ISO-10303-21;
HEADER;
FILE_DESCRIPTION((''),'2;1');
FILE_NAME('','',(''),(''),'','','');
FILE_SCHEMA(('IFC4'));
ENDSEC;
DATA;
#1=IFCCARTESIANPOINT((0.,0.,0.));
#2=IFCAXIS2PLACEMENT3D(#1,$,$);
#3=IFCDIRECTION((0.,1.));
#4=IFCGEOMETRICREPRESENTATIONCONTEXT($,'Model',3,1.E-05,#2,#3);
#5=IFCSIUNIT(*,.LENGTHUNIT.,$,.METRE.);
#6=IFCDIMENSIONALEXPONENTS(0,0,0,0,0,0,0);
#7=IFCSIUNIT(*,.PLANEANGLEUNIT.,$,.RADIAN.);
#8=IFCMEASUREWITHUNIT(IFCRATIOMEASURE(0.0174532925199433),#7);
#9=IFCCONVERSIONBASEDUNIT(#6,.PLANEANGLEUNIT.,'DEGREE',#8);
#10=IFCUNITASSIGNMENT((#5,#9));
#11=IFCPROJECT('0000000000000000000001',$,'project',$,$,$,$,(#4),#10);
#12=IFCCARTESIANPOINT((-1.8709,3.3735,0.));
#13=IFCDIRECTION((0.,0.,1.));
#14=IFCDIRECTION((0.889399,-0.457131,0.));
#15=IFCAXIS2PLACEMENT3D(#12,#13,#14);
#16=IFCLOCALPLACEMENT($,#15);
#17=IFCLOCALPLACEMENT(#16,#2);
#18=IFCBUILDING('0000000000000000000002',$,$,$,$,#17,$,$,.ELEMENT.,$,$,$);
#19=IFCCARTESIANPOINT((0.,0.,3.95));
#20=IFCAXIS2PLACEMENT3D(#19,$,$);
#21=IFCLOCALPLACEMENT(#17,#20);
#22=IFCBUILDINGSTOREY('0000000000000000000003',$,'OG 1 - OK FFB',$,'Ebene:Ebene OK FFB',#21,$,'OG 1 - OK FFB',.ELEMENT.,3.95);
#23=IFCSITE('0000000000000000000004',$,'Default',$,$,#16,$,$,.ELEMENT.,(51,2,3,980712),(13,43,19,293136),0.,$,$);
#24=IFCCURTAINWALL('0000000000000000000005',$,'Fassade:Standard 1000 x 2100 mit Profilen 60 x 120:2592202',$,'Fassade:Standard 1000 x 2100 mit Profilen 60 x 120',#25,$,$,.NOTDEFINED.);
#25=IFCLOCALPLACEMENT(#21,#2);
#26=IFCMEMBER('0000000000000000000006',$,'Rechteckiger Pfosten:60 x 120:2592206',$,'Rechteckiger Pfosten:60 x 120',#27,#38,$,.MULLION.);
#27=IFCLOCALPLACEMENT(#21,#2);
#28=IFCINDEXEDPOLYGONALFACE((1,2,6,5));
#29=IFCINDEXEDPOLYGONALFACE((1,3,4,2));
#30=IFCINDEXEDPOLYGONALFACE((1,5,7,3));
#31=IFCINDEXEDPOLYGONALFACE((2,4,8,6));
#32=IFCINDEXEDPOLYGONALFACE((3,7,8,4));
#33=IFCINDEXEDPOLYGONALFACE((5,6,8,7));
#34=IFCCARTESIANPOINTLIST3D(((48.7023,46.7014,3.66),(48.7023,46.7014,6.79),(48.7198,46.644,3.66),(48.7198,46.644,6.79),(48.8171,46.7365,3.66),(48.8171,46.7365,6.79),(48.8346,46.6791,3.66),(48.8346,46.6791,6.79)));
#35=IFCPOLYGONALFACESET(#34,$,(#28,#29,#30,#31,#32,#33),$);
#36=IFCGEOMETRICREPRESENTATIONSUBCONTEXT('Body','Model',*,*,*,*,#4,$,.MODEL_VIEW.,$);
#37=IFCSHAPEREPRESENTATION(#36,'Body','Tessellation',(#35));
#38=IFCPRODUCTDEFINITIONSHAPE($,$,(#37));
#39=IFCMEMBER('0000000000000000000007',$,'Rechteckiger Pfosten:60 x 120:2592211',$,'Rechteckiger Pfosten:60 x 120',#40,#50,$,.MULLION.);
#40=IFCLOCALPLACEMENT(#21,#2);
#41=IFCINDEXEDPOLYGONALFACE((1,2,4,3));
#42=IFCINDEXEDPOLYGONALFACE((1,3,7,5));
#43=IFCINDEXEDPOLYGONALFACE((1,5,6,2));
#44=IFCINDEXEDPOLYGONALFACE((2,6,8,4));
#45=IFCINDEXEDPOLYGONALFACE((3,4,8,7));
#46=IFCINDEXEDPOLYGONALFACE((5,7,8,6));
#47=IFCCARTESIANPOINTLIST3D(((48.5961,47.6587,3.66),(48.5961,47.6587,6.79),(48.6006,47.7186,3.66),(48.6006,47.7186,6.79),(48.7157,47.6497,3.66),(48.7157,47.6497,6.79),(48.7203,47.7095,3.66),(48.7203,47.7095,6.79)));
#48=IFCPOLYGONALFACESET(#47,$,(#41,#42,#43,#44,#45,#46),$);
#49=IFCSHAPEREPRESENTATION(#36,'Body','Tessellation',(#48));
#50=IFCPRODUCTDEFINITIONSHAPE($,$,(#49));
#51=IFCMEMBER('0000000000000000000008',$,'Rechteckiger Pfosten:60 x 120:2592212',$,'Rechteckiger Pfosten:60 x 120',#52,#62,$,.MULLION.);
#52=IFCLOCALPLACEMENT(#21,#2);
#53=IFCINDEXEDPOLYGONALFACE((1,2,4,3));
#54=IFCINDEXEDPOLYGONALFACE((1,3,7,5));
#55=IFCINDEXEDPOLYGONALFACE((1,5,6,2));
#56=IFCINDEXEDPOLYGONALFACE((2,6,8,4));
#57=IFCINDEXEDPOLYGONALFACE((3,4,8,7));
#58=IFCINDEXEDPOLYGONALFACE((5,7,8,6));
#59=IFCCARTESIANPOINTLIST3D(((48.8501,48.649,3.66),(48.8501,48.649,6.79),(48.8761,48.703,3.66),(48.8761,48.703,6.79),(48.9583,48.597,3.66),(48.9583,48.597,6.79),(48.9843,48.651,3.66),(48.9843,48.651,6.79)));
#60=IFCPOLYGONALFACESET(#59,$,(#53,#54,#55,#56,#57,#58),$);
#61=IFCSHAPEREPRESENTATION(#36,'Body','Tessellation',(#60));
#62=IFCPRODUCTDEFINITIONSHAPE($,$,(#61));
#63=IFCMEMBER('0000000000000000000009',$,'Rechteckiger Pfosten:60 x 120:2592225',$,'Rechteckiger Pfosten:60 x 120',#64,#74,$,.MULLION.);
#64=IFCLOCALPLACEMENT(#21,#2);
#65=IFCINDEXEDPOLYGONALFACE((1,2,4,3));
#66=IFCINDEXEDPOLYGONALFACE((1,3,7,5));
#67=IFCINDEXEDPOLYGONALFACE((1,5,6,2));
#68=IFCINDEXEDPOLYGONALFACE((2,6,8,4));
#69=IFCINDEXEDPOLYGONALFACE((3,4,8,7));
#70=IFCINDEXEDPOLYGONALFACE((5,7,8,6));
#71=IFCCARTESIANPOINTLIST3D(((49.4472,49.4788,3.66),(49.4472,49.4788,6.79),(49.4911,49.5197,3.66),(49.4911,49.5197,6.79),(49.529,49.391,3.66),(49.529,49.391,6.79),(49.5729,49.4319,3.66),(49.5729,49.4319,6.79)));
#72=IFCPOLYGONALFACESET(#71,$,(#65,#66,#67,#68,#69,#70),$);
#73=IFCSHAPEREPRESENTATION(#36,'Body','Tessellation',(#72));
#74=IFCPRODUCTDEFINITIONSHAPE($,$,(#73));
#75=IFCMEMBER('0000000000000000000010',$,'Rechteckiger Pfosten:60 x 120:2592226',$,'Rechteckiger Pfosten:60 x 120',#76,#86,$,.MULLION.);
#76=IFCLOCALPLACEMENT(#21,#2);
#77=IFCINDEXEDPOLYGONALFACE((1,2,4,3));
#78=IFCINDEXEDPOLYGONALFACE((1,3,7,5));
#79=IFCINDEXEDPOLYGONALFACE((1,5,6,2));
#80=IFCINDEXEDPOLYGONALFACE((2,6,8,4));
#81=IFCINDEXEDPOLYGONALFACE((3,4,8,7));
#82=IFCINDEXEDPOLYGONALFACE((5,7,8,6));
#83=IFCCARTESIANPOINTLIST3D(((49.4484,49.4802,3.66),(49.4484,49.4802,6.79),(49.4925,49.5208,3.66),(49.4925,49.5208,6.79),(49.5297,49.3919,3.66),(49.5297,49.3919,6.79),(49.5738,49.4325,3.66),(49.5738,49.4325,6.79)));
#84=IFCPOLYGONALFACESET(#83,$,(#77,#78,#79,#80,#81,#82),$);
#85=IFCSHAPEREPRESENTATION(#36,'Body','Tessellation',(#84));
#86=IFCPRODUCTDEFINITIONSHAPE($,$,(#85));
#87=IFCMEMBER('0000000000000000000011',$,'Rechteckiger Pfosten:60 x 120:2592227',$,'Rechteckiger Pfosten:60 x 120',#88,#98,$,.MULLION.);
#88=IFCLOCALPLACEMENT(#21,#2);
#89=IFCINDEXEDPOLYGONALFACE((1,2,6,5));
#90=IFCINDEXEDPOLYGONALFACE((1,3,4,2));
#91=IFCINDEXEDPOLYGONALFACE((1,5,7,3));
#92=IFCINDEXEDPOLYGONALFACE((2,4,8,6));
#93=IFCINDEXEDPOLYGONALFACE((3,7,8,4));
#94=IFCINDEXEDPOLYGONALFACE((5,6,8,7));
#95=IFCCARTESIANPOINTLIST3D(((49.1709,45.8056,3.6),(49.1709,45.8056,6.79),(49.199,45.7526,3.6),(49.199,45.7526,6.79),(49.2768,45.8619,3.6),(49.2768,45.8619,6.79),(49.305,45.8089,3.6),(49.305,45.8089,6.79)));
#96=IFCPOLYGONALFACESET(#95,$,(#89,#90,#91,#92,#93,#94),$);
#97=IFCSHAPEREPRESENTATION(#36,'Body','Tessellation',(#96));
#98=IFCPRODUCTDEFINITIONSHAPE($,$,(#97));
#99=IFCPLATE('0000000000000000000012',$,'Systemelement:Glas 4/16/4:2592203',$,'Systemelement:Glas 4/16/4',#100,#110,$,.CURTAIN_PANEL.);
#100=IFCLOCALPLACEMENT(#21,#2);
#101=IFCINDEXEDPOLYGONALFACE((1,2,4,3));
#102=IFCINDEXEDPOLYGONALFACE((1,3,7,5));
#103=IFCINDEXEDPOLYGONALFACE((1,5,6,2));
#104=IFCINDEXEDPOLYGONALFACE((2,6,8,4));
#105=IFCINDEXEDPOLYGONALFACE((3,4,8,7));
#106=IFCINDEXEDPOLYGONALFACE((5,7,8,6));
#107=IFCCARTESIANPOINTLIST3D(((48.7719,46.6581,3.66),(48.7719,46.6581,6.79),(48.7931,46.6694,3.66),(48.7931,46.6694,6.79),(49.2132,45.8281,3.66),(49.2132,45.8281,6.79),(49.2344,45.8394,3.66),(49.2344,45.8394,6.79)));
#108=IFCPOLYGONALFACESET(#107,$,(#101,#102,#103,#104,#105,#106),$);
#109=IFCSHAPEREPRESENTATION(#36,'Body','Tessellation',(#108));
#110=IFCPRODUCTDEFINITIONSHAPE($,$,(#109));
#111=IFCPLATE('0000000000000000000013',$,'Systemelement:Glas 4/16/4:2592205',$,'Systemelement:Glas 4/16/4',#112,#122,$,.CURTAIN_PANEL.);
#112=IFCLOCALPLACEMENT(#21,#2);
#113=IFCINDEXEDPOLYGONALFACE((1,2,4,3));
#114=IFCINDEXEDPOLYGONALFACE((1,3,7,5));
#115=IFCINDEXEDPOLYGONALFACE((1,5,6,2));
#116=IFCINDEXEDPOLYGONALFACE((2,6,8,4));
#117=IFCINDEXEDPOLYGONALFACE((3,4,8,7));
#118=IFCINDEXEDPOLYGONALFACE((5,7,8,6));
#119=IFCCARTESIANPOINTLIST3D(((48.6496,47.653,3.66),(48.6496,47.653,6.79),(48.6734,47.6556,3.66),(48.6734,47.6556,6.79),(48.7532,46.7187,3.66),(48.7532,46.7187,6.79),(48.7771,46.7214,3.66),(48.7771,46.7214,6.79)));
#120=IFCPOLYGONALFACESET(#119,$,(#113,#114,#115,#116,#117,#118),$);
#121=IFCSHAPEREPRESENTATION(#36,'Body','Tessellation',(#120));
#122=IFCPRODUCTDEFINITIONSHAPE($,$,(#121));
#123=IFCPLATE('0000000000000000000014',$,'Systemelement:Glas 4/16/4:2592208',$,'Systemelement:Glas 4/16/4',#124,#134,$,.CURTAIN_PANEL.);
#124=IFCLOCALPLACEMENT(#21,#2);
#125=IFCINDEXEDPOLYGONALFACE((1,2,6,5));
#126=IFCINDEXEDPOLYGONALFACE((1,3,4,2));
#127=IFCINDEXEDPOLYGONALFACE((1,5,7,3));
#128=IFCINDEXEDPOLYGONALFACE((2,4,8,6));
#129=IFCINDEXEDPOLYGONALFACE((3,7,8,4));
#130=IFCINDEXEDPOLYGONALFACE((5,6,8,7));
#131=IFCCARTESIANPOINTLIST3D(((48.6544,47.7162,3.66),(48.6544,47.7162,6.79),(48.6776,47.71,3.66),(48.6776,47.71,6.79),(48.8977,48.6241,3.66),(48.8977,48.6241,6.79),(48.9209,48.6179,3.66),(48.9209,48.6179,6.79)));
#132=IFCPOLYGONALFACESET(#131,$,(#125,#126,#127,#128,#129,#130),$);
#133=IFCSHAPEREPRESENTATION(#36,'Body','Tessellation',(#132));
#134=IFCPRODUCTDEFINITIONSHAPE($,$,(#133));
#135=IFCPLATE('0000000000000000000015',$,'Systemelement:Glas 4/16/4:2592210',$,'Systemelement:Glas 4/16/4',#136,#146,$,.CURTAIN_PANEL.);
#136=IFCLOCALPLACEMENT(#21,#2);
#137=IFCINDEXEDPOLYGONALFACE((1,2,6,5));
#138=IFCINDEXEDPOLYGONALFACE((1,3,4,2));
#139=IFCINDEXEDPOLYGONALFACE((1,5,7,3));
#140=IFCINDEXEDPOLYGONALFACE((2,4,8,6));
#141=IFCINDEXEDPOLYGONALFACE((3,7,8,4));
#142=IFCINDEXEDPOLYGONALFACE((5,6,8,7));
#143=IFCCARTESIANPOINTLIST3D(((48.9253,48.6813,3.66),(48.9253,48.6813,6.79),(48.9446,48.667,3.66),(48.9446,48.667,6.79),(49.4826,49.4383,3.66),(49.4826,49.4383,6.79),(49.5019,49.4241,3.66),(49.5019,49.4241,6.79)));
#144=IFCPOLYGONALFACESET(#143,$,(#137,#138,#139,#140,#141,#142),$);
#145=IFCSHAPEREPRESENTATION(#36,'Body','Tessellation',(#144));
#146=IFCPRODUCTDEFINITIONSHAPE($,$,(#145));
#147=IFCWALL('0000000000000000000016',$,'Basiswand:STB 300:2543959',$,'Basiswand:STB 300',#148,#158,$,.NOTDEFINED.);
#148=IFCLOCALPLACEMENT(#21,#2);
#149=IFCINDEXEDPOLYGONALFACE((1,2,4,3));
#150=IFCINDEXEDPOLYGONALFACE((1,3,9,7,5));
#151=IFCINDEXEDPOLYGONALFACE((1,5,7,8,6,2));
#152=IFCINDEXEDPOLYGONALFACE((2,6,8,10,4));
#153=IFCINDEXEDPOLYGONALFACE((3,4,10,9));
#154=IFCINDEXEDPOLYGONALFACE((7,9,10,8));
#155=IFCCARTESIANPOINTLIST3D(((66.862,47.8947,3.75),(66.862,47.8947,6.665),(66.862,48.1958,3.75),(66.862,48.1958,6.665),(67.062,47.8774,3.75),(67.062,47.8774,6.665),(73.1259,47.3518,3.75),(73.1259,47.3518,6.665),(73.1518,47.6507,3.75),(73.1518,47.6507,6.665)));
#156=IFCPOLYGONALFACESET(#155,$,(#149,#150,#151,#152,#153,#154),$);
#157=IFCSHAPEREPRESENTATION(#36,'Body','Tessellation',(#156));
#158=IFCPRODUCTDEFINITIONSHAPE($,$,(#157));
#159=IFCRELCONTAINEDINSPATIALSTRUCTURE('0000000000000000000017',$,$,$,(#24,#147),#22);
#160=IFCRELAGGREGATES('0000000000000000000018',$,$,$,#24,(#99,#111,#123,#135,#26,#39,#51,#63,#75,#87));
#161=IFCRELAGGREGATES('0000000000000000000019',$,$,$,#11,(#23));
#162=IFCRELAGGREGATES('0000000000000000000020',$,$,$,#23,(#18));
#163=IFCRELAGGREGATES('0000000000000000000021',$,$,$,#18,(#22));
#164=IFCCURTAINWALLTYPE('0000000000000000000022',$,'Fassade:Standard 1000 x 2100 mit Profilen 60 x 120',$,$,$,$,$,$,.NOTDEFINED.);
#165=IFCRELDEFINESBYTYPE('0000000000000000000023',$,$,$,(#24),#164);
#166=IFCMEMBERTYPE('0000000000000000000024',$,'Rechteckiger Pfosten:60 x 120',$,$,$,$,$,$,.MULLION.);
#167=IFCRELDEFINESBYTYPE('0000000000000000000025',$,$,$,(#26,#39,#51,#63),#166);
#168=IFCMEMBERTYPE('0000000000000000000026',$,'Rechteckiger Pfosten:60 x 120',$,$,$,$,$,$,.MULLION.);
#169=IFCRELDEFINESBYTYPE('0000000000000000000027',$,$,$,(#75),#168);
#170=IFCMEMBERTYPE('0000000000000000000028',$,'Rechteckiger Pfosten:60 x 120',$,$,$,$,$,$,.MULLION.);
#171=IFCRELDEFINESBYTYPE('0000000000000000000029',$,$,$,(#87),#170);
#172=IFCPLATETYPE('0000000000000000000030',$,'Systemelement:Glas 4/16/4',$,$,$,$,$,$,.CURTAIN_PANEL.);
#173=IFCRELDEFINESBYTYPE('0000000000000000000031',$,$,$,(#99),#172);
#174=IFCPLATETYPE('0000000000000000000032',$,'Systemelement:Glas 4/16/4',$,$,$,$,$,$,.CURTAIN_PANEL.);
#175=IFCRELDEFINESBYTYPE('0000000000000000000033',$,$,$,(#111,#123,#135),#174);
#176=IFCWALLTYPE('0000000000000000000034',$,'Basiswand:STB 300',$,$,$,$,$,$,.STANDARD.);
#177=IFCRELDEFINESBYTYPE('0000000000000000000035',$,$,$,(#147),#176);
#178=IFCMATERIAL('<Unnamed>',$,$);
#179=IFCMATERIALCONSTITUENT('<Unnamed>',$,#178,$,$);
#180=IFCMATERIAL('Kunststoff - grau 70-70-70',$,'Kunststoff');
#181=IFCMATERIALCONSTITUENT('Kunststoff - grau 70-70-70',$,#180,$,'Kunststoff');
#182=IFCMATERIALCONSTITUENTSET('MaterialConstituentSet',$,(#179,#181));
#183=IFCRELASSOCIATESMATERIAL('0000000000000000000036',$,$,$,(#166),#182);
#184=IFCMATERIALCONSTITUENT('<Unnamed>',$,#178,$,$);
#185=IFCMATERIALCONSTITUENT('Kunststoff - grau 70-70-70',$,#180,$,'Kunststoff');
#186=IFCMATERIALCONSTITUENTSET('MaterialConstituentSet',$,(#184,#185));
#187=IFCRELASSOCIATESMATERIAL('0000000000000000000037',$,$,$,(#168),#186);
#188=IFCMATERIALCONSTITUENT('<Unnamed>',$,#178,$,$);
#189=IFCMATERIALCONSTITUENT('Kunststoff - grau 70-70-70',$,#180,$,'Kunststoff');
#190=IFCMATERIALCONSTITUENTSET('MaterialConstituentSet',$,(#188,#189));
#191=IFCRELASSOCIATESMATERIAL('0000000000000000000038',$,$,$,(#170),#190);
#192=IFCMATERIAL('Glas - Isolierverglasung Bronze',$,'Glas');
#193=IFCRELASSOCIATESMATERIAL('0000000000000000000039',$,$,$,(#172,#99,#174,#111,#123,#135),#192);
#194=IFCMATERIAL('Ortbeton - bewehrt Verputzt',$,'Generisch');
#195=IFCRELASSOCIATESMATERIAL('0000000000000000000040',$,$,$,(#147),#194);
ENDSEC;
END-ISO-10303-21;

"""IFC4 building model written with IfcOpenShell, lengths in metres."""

from ifc_helpers import new_model, entity, si_unit, converted_unit, direction, frame, origin, place, context, subcontext, project, spatial, indexed_curve, outline, extrude, source, transform, mapped, material, constituent, constituent_set, type_object, type_shapes, element, aggregate, save


model = new_model("IFC4")

# Units and contexts
model_context = context("Model", 3, precision=1e-05, world=origin(), true_north=direction((0.0, 1.0)))
body_context = subcontext(model_context, "Body", "Model", "MODEL_VIEW")
ifc_project = project(units=[si_unit("LENGTHUNIT", "METRE"), converted_unit("PLANEANGLEUNIT", "DEGREE", entity("IfcRatioMeasure", 0.0174532925199433), si_unit("PLANEANGLEUNIT", "RADIAN"), dimensions=[0, 0, 0, 0, 0, 0, 0])], contexts=[model_context])

# Site, building, storey
site_placement = place(None, frame((-1.8709, 3.3735, 0.0), z_axis=(0.0, 0.0, 1.0), x_axis=(0.889399, -0.457131, 0.0)))
site = spatial("IfcSite", under=ifc_project, at=site_placement, Name="Default", CompositionType="ELEMENT", RefLatitude=(51, 2, 3, 980712), RefLongitude=(13, 43, 19, 293136), RefElevation=0.0)
building_placement = place(site_placement, origin())
building = spatial("IfcBuilding", under=site, at=building_placement, CompositionType="ELEMENT")
storey_placement = place(building_placement, frame((0.0, 0.0, 3.95)))
storey = spatial("IfcBuildingStorey", under=building, at=storey_placement, Name="OG 1 - OK FFB", ObjectType="Ebene:Ebene OK FFB", LongName="OG 1 - OK FFB", CompositionType="ELEMENT", Elevation=3.95)

# Shared definitions
ifc_material_1 = material(Name="Ortbeton - bewehrt Verputzt", Category="Generisch")

# Curtain wall, members
curtain_wall_type = type_object("IfcCurtainWallType", Name="Fassade:Standard 1000 x 2100 mit Profilen 60 x 120", PredefinedType="NOTDEFINED")
curtain_wall_placement = place(storey_placement, frame((0.0, 0.0, -3.95)))
curtain_wall = element("IfcCurtainWall", 1, at=curtain_wall_placement, inside=storey, type_object=curtain_wall_type, Name="Fassade:Standard 1000 x 2100 mit Profilen 60 x 120:2592202", ObjectType="Fassade:Standard 1000 x 2100 mit Profilen 60 x 120", PredefinedType="NOTDEFINED")
ifc_material_2 = material(Name="<Unnamed>")
ifc_constituent_1 = constituent(ifc_material_2, Name="<Unnamed>")
ifc_material_3 = material(Name="Kunststoff - grau 70-70-70", Category="Kunststoff")
ifc_constituent_2 = constituent(ifc_material_3, Name="Kunststoff - grau 70-70-70", Category="Kunststoff")
ifc_constituent_set_1 = constituent_set(constituents=[ifc_constituent_1, ifc_constituent_2], Name="MaterialConstituentSet")
member_type_1 = type_object("IfcMemberType", Name="Rechteckiger Pfosten:60 x 120", PredefinedType="MULLION", material=ifc_constituent_set_1)
shared_shape_1 = source(origin(), body_context, "Body", "SweptSolid", [
    extrude(outline(indexed_curve([(-0.06, -0.03), (0.06, -0.03), (0.06, 0.03), (-0.06, 0.03), (-0.06, -0.03)], self_intersect=False)), frame((0.0, 0.0, -3.13), z_axis=(0.0, 0.0, 1.0), x_axis=(0.0, -1.0, 0.0)), (0.0, 0.0, 1.0), 3.13),
])
type_shapes(member_type_1, [shared_shape_1])
member_1_placement = place(curtain_wall_placement, frame((48.7685, 46.6902, 7.61), z_axis=(0.0, 0.0, -1.0), x_axis=(-0.292429, 0.956287, 0.0)))
member_1 = element("IfcMember", 2, at=member_1_placement, type_object=member_type_1, Name="Rechteckiger Pfosten:60 x 120:2592206", ObjectType="Rechteckiger Pfosten:60 x 120", PredefinedType="MULLION", context=body_context, shape_type="MappedRepresentation", body=[
    mapped(shared_shape_1, transform((0.0, 0.0, 0.0), scale=1.0)),
])
member_2_placement = place(curtain_wall_placement, frame((48.6582, 47.6841, 7.61), z_axis=(0.0, 0.0, -1.0), x_axis=(0.075683, 0.997132, 0.0)))
member_2 = element("IfcMember", 3, at=member_2_placement, type_object=member_type_1, Name="Rechteckiger Pfosten:60 x 120:2592211", ObjectType="Rechteckiger Pfosten:60 x 120", PredefinedType="MULLION", context=body_context, shape_type="MappedRepresentation", body=[
    mapped(shared_shape_1, transform((0.0, 0.0, 0.0), scale=1.0)),
])
member_3_placement = place(curtain_wall_placement, frame((48.9172, 48.65, 7.61), z_axis=(0.0, 0.0, -1.0), x_axis=(0.433412, 0.901196, 0.0)))
member_3 = element("IfcMember", 4, at=member_3_placement, type_object=member_type_1, Name="Rechteckiger Pfosten:60 x 120:2592212", ObjectType="Rechteckiger Pfosten:60 x 120", PredefinedType="MULLION", context=body_context, shape_type="MappedRepresentation", body=[
    mapped(shared_shape_1, transform((0.0, 0.0, 0.0), scale=1.0)),
])
member_4_placement = place(curtain_wall_placement, frame((49.51, 49.4553, 7.61), z_axis=(0.0, 0.0, -1.0), x_axis=(0.731689, 0.681639, 0.0)))
member_4 = element("IfcMember", 5, at=member_4_placement, type_object=member_type_1, Name="Rechteckiger Pfosten:60 x 120:2592225", ObjectType="Rechteckiger Pfosten:60 x 120", PredefinedType="MULLION", context=body_context, shape_type="MappedRepresentation", body=[
    mapped(shared_shape_1, transform((0.0, 0.0, 0.0), scale=1.0)),
])
ifc_constituent_3 = constituent(ifc_material_2, Name="<Unnamed>")
ifc_constituent_4 = constituent(ifc_material_3, Name="Kunststoff - grau 70-70-70", Category="Kunststoff")
ifc_constituent_set_2 = constituent_set(constituents=[ifc_constituent_3, ifc_constituent_4], Name="MaterialConstituentSet")
member_type_2 = type_object("IfcMemberType", Name="Rechteckiger Pfosten:60 x 120", PredefinedType="MULLION", material=ifc_constituent_set_2)
shared_shape_2 = source(origin(), body_context, "Body", "SweptSolid", [
    extrude(outline(indexed_curve([(-0.06, -0.03), (0.06, -0.03), (0.06, 0.03), (-0.06, 0.03), (-0.06, -0.03)], self_intersect=False)), frame((-0.03, 0.0, -3.13), z_axis=(0.0, 0.0, 1.0), x_axis=(0.0, -1.0, 0.0)), (0.0, 0.0, 1.0), 3.13),
])
type_shapes(member_type_2, [shared_shape_2])
member_5_placement = place(curtain_wall_placement, frame((49.5332, 49.4767, 7.61), z_axis=(0.0, 0.0, -1.0), x_axis=(0.735649, 0.677363, 0.0)))
member_5 = element("IfcMember", 6, at=member_5_placement, type_object=member_type_2, Name="Rechteckiger Pfosten:60 x 120:2592226", ObjectType="Rechteckiger Pfosten:60 x 120", PredefinedType="MULLION", context=body_context, shape_type="MappedRepresentation", body=[
    mapped(shared_shape_2, transform((0.0, 0.0, 0.0), scale=1.0)),
])
ifc_constituent_5 = constituent(ifc_material_2, Name="<Unnamed>")
ifc_constituent_6 = constituent(ifc_material_3, Name="Kunststoff - grau 70-70-70", Category="Kunststoff")
ifc_constituent_set_3 = constituent_set(constituents=[ifc_constituent_5, ifc_constituent_6], Name="MaterialConstituentSet")
member_type_3 = type_object("IfcMemberType", Name="Rechteckiger Pfosten:60 x 120", PredefinedType="MULLION", material=ifc_constituent_set_3)
shared_shape_3 = source(origin(), body_context, "Body", "SweptSolid", [
    extrude(outline(indexed_curve([(-0.06, -0.03), (0.06, -0.03), (0.06, 0.03), (-0.06, 0.03), (-0.06, -0.03)], self_intersect=False)), frame((-0.03, 0.0, -3.19), z_axis=(0.0, 0.0, 1.0), x_axis=(0.0, -1.0, 0.0)), (0.0, 0.0, 1.0), 3.19),
])
type_shapes(member_type_3, [shared_shape_3])
member_6_placement = place(curtain_wall_placement, frame((49.252, 45.7808, 10.74), z_axis=(0.0, 0.0, 1.0), x_axis=(0.469463, -0.882952, 0.0)))
member_6 = element("IfcMember", 7, at=member_6_placement, type_object=member_type_3, Name="Rechteckiger Pfosten:60 x 120:2592227", ObjectType="Rechteckiger Pfosten:60 x 120", PredefinedType="MULLION", context=body_context, shape_type="MappedRepresentation", body=[
    mapped(shared_shape_3, transform((0.0, 0.0, 0.0), scale=1.0)),
])

# Plates
ifc_material_4 = material(Name="Glas - Isolierverglasung Bronze", Category="Glas")
plate_type_1 = type_object("IfcPlateType", Name="Systemelement:Glas 4/16/4", PredefinedType="CURTAIN_PANEL", material=ifc_material_4)
shared_shape_4 = source(origin(), body_context, "Body", "SweptSolid", [
    extrude(outline(indexed_curve([(-0.012, -0.47), (0.012, -0.47), (0.012, 0.47), (-0.012, 0.47), (-0.012, -0.47)], self_intersect=False)), frame((0.0, 0.0, 0.0), z_axis=(0.0, 0.0, 1.0), x_axis=(0.0, 1.0, 0.0)), (0.0, 0.0, 1.0), 3.13),
])
type_shapes(plate_type_1, [shared_shape_4])
plate_1_placement = place(curtain_wall_placement, frame((49.0032, 46.2487, 7.61), z_axis=(0.0, 0.0, 1.0), x_axis=(-0.469463, 0.882952, 0.0)))
plate_1 = element("IfcPlate", 8, at=plate_1_placement, type_object=plate_type_1, material=ifc_material_4, Name="Systemelement:Glas 4/16/4:2592203", ObjectType="Systemelement:Glas 4/16/4", PredefinedType="CURTAIN_PANEL", context=body_context, shape_type="MappedRepresentation", body=[
    mapped(shared_shape_4, transform((0.0, 0.0, 0.0), scale=1.0)),
])
plate_type_2 = type_object("IfcPlateType", Name="Systemelement:Glas 4/16/4", PredefinedType="CURTAIN_PANEL", material=ifc_material_4)
shared_shape_5 = source(origin(), body_context, "Body", "SweptSolid", [
    extrude(outline(indexed_curve([(-0.012, -0.47), (0.012, -0.47), (0.012, 0.47), (-0.012, 0.47), (-0.012, -0.47)], self_intersect=False)), frame((0.0, 0.0, 0.0), z_axis=(0.0, 0.0, 1.0), x_axis=(0.0, 1.0, 0.0)), (0.0, 0.0, 1.0), 3.13),
])
type_shapes(plate_type_2, [shared_shape_5])
plate_2_placement = place(curtain_wall_placement, frame((48.7133, 47.1872, 7.61), z_axis=(0.0, 0.0, 1.0), x_axis=(-0.110281, 0.9939, 0.0)))
plate_2 = element("IfcPlate", 9, at=plate_2_placement, type_object=plate_type_2, material=ifc_material_4, Name="Systemelement:Glas 4/16/4:2592205", ObjectType="Systemelement:Glas 4/16/4", PredefinedType="CURTAIN_PANEL", context=body_context, shape_type="MappedRepresentation", body=[
    mapped(shared_shape_5, transform((0.0, 0.0, 0.0), scale=1.0)),
])
plate_3_placement = place(curtain_wall_placement, frame((48.7877, 48.1671, 7.61), z_axis=(0.0, 0.0, 1.0), x_axis=(0.258819, 0.965926, 0.0)))
plate_3 = element("IfcPlate", 10, at=plate_3_placement, type_object=plate_type_2, material=ifc_material_4, Name="Systemelement:Glas 4/16/4:2592208", ObjectType="Systemelement:Glas 4/16/4", PredefinedType="CURTAIN_PANEL", context=body_context, shape_type="MappedRepresentation", body=[
    mapped(shared_shape_5, transform((0.0, 0.0, 0.0), scale=1.0)),
])
plate_4_placement = place(curtain_wall_placement, frame((49.2136, 49.0527, 7.61), z_axis=(0.0, 0.0, 1.0), x_axis=(0.592804, 0.805347, 0.0)))
plate_4 = element("IfcPlate", 11, at=plate_4_placement, type_object=plate_type_2, material=ifc_material_4, Name="Systemelement:Glas 4/16/4:2592210", ObjectType="Systemelement:Glas 4/16/4", PredefinedType="CURTAIN_PANEL", context=body_context, shape_type="MappedRepresentation", body=[
    mapped(shared_shape_5, transform((0.0, 0.0, 0.0), scale=1.0)),
])
aggregate(curtain_wall, [plate_1, plate_2, plate_3, plate_4, member_1, member_2, member_3, member_4, member_5, member_6])

# Wall
wall_type_1 = type_object("IfcWallType", Name="Basiswand:STB 300", PredefinedType="STANDARD")
wall_1_placement = place(storey_placement, frame((66.849, 48.0464, 3.75), z_axis=(0.0, 0.0, 1.0), x_axis=(0.996265, -0.086344, 0.0)))
element("IfcWall", 12, at=wall_1_placement, inside=storey, type_object=wall_type_1, material=ifc_material_1, Name="Basiswand:STB 300:2543959", ObjectType="Basiswand:STB 300", PredefinedType="NOTDEFINED", context=body_context, shape_type="SweptSolid", body=[
    extrude(outline(indexed_curve([(6.3134, -0.15), (6.3134, 0.15), (0.0, 0.15), (0.026, -0.15), (0.2268, -0.15), (6.3134, -0.15)], self_intersect=False)), origin(), (0.0, 0.0, 1.0), 2.915),
])

save(model, "model.ifc")
